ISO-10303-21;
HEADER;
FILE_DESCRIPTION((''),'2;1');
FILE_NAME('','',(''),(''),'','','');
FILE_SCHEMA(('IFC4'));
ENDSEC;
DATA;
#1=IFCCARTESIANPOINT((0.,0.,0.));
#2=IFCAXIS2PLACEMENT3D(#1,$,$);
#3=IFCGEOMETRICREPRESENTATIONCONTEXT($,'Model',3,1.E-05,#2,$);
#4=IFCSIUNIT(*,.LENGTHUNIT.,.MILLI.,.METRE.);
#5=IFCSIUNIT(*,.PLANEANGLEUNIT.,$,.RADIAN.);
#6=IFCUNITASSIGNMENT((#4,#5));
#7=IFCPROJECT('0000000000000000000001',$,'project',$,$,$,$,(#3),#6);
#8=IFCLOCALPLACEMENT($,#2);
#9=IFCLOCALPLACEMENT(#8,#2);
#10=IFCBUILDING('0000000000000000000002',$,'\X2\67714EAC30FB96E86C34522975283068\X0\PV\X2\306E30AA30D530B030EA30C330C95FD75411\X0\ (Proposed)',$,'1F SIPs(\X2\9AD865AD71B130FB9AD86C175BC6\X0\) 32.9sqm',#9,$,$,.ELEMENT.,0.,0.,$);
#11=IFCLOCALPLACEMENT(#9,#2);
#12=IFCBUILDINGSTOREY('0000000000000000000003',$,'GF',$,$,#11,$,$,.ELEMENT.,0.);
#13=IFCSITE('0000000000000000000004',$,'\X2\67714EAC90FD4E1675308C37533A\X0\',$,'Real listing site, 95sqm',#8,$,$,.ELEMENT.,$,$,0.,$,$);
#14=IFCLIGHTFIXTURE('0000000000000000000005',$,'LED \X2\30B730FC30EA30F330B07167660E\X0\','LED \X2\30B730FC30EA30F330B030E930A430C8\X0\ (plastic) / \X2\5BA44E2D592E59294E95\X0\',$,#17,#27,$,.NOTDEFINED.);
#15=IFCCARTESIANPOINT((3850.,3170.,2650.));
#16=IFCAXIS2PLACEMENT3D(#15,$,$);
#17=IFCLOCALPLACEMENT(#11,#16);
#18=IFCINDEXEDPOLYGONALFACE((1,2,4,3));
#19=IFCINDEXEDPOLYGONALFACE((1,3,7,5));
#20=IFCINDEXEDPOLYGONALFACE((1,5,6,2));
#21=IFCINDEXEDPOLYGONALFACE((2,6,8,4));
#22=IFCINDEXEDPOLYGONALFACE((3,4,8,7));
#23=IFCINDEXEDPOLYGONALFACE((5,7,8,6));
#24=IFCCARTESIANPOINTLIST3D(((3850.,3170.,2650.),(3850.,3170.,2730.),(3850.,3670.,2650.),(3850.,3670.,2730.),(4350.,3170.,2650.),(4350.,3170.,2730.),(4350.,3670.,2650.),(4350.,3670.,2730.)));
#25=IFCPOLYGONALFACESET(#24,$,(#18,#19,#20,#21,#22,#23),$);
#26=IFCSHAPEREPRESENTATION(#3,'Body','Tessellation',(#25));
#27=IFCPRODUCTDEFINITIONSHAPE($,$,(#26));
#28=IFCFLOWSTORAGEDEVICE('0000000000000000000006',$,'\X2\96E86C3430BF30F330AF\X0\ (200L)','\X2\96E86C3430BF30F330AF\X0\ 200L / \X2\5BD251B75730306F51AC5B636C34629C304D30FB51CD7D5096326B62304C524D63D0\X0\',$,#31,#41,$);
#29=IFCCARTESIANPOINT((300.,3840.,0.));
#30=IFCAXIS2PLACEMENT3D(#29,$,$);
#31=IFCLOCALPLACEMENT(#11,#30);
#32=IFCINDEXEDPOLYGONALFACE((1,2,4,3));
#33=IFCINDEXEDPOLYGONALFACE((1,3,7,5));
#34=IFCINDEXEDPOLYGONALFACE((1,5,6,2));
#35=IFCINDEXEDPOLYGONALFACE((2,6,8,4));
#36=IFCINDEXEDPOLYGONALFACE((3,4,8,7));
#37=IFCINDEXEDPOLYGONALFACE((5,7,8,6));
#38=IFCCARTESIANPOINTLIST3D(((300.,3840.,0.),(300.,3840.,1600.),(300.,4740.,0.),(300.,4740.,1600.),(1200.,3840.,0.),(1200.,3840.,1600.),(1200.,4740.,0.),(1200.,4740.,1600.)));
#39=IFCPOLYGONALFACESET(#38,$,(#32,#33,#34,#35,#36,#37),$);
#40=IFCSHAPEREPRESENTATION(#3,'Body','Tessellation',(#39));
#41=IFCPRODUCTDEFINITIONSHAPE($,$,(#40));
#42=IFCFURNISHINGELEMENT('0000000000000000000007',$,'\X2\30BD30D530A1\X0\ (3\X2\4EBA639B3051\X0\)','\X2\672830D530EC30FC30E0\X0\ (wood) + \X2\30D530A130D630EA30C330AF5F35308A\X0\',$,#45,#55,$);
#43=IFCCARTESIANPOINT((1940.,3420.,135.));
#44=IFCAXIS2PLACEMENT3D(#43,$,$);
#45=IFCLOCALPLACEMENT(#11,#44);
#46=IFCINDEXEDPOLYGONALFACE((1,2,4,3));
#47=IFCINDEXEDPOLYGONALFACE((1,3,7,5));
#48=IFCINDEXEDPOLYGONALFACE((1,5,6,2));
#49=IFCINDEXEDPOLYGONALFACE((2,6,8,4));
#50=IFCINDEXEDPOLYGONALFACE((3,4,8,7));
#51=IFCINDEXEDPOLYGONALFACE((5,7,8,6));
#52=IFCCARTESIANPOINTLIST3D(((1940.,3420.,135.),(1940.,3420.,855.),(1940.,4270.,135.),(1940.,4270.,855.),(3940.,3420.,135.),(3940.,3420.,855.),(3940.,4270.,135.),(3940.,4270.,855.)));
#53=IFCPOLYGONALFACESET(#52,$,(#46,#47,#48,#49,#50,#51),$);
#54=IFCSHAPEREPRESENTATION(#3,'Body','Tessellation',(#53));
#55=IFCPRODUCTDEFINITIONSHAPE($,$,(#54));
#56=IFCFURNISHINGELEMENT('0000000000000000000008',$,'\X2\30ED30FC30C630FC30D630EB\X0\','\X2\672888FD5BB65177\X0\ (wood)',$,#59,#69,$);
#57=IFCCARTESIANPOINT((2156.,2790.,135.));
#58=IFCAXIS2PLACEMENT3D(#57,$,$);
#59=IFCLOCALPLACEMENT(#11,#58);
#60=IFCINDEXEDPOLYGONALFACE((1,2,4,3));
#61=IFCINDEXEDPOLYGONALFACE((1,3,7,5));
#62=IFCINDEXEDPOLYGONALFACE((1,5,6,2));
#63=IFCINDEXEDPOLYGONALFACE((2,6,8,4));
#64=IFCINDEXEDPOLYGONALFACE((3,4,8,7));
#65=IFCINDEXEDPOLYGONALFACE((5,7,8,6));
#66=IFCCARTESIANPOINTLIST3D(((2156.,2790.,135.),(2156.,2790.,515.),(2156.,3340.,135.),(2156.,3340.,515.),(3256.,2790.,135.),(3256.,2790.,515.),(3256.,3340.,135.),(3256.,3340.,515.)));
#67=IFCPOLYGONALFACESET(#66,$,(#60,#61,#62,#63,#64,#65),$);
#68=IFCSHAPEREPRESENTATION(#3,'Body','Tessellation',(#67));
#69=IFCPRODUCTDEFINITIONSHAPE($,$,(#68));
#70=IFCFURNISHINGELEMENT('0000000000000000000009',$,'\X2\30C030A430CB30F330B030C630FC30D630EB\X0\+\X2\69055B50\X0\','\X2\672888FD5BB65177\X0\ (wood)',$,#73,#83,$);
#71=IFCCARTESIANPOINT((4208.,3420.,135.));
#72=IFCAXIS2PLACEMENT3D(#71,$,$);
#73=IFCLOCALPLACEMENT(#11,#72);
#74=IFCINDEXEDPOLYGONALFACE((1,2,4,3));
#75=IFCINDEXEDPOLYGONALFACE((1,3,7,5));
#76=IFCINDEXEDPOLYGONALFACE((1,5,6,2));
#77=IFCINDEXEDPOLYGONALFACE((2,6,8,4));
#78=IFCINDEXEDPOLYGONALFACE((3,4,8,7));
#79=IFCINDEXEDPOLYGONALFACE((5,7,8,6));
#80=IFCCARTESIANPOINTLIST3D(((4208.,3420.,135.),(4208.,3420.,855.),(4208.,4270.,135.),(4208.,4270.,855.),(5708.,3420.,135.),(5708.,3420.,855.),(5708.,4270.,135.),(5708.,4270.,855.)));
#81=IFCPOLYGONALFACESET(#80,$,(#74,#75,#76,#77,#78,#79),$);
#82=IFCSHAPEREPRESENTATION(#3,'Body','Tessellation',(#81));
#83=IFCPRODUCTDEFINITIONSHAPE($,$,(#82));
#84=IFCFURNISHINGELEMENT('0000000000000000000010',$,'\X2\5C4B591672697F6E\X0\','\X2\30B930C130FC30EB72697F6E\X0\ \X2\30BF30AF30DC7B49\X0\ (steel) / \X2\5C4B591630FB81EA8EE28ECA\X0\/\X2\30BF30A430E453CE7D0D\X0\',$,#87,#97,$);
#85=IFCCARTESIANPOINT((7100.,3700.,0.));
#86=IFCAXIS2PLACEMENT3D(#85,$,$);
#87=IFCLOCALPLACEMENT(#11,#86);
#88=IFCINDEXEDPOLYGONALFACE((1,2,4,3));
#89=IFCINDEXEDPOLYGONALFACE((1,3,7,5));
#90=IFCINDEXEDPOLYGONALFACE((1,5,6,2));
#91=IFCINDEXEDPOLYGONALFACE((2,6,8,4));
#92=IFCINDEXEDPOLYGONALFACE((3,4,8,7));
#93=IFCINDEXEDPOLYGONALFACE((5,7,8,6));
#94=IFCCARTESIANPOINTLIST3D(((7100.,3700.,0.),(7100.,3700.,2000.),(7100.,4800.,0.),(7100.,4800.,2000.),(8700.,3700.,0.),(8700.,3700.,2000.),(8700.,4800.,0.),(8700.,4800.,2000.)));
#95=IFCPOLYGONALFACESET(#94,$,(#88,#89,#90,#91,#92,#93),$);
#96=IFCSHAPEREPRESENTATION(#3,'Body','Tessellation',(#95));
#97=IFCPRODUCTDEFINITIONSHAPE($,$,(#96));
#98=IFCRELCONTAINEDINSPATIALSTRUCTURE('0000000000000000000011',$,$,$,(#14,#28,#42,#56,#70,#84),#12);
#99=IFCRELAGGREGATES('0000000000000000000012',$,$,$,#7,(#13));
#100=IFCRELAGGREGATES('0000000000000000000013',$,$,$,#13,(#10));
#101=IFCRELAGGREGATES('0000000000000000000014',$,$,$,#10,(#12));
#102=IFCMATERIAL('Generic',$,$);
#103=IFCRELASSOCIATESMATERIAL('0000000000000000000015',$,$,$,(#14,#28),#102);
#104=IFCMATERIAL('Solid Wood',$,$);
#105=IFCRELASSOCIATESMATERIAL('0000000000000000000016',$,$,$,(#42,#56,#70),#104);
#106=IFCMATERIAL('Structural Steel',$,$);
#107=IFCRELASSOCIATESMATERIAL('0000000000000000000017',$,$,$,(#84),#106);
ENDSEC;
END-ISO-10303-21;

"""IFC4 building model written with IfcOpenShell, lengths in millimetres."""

from ifc_helpers import new_model, si_unit, frame, frame_2d, origin, place, context, project, spatial, rectangle, extrude, material, element, save


model = new_model("IFC4")

# Units and contexts
model_context = context("Model", 3, precision=1e-05, world=origin())
ifc_project = project(units=[si_unit("LENGTHUNIT", "METRE", prefix="MILLI"), si_unit("PLANEANGLEUNIT", "RADIAN")], contexts=[model_context])

# Site, building, storey
site_placement = place(None, origin())
site = spatial("IfcSite", under=ifc_project, at=site_placement, Name="東京都世田谷区", ObjectType="Real listing site, 95sqm", CompositionType="ELEMENT", RefElevation=0.0)
building_placement = place(site_placement, origin())
building = spatial("IfcBuilding", under=site, at=building_placement, Name="東京・雨水利用とPVのオフグリッド志向 (Proposed)", ObjectType="1F SIPs(高断熱・高気密) 32.9sqm", CompositionType="ELEMENT", ElevationOfRefHeight=0.0, ElevationOfTerrain=0.0)
storey_placement = place(building_placement, origin())
storey = spatial("IfcBuildingStorey", under=building, at=storey_placement, Name="GF", CompositionType="ELEMENT", Elevation=0.0)

# Shared definitions
ifc_material_1 = material(Name="Solid Wood")

# Shared definitions
ifc_material_2 = material(Name="Structural Steel")

# Light fixture
ifc_material_3 = material(Name="Generic")
light_fixture_placement = place(storey_placement, frame((3850.0, 3170.0, 2650.0)))
element("IfcLightFixture", 1, at=light_fixture_placement, inside=storey, material=ifc_material_3, Name="LED シーリング照明", Description="LED シーリングライト (plastic) / 室中央天井", PredefinedType="NOTDEFINED", context=model_context, shape_type="SweptSolid", body=[
    extrude(rectangle(XDim=500.0, YDim=500.0, at=frame_2d((250.0, 250.0))), frame((3850.0, 3170.0, 2650.0)), (0.0, 0.0, 1.0), 80.0),
])

# Flow storage device
flow_storage_device_placement = place(storey_placement, frame((300.0, 3840.0, 0.0)))
element("IfcFlowStorageDevice", 2, at=flow_storage_device_placement, inside=storey, material=ifc_material_3, Name="雨水タンク (200L)", Description="雨水タンク 200L / 寒冷地は冬季水抜き・凍結防止が前提", context=model_context, shape_type="SweptSolid", body=[
    extrude(rectangle(XDim=900.0, YDim=900.0, at=frame_2d((450.0, 450.0))), frame((300.0, 3840.0, 0.0)), (0.0, 0.0, 1.0), 1600.0),
])

# Furnishing elements
furnishing_1_placement = place(storey_placement, frame((1940.0, 3420.0, 135.0)))
element("IfcFurnishingElement", 3, at=furnishing_1_placement, inside=storey, material=ifc_material_1, Name="ソファ (3人掛け)", Description="木フレーム (wood) + ファブリック張り", context=model_context, shape_type="SweptSolid", body=[
    extrude(rectangle(XDim=2000.0, YDim=850.0, at=frame_2d((1000.0, 425.0))), frame((1940.0, 3420.0, 135.0)), (0.0, 0.0, 1.0), 720.0),
])
furnishing_2_placement = place(storey_placement, frame((2156.0, 2790.0, 135.0)))
element("IfcFurnishingElement", 4, at=furnishing_2_placement, inside=storey, material=ifc_material_1, Name="ローテーブル", Description="木製家具 (wood)", context=model_context, shape_type="SweptSolid", body=[
    extrude(rectangle(XDim=1100.0, YDim=550.0, at=frame_2d((550.0, 275.0))), frame((2156.0, 2790.0, 135.0)), (0.0, 0.0, 1.0), 380.0),
])
furnishing_3_placement = place(storey_placement, frame((4208.0, 3420.0, 135.0)))
element("IfcFurnishingElement", 5, at=furnishing_3_placement, inside=storey, material=ifc_material_1, Name="ダイニングテーブル+椅子", Description="木製家具 (wood)", context=model_context, shape_type="SweptSolid", body=[
    extrude(rectangle(XDim=1500.0, YDim=850.0, at=frame_2d((750.0, 425.0))), frame((4208.0, 3420.0, 135.0)), (0.0, 0.0, 1.0), 720.0),
])
furnishing_4_placement = place(storey_placement, frame((7100.0, 3700.0, 0.0)))
element("IfcFurnishingElement", 6, at=furnishing_4_placement, inside=storey, material=ifc_material_2, Name="屋外物置", Description="スチール物置 タクボ等 (steel) / 屋外・自転車/タイヤ収納", context=model_context, shape_type="SweptSolid", body=[
    extrude(rectangle(XDim=1600.0, YDim=1100.0, at=frame_2d((800.0, 550.0))), frame((7100.0, 3700.0, 0.0)), (0.0, 0.0, 1.0), 2000.0),
])

save(model, "model.ifc")
